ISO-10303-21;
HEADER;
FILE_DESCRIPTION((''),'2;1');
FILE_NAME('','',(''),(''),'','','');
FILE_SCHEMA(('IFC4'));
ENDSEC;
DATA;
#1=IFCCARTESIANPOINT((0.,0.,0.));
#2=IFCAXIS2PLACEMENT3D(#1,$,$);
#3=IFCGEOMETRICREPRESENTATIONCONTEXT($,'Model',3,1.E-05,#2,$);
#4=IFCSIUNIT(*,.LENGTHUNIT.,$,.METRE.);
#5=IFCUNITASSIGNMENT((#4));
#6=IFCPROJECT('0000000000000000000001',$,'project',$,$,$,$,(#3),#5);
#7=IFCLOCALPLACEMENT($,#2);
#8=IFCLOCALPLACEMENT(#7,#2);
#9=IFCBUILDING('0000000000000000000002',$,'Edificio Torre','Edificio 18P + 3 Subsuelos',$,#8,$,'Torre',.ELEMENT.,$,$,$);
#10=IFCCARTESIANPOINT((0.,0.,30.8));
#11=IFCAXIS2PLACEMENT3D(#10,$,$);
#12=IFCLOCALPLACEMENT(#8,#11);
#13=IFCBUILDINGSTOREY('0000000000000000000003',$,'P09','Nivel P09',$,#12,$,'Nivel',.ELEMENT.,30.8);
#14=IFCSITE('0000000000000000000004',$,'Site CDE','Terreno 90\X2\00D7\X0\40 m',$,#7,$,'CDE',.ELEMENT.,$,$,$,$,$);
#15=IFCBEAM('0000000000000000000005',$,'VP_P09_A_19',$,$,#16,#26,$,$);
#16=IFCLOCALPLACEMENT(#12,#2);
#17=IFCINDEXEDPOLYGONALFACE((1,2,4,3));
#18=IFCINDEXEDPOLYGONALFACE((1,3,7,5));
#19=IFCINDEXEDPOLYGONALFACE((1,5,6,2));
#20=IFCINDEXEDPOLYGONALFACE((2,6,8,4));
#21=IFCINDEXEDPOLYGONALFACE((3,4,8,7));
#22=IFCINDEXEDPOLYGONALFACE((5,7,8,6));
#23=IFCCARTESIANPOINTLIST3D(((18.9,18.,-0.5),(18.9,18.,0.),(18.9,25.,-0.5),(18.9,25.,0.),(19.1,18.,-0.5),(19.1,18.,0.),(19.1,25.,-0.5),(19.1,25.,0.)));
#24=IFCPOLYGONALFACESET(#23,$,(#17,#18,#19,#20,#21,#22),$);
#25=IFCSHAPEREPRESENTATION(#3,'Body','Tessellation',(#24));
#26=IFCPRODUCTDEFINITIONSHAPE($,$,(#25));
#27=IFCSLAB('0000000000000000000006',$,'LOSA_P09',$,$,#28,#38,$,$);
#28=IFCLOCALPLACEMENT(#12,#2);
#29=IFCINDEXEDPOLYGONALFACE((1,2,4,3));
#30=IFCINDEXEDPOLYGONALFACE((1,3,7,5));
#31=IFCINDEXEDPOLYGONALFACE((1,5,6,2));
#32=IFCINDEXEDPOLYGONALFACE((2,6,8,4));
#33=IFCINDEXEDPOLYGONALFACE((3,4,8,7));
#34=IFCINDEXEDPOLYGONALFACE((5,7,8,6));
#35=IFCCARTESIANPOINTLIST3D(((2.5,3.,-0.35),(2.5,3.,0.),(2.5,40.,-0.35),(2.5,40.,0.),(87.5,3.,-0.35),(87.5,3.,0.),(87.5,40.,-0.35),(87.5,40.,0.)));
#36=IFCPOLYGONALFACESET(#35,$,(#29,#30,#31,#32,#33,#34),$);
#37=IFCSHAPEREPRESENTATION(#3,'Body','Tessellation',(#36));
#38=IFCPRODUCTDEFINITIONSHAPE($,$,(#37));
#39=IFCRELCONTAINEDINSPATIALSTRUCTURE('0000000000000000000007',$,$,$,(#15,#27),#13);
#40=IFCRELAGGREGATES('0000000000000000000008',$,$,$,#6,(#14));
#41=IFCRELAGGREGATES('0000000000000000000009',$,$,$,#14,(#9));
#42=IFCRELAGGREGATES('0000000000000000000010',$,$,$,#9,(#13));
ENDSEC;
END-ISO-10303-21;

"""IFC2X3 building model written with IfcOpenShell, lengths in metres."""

from ifc_helpers import new_model, si_unit, frame, origin, origin_2d, place, context, project, spatial, rectangle, extrude, element, save


model = new_model("IFC2X3")

# Units and contexts
model_context = context("Model", 3, precision=1e-05, world=origin())
ifc_project = project(units=[si_unit("LENGTHUNIT", "METRE")], contexts=[model_context])

# Site, building, storey
site_placement = place(None, origin())
site = spatial("IfcSite", under=ifc_project, at=site_placement, Name="Site CDE", Description="Terreno 90×40 m", LongName="CDE", CompositionType="ELEMENT")
building_placement = place(site_placement, origin())
building = spatial("IfcBuilding", under=site, at=building_placement, Name="Edificio Torre", Description="Edificio 18P + 3 Subsuelos", LongName="Torre", CompositionType="ELEMENT")
storey_placement = place(building_placement, frame((0.0, 0.0, 30.8)))
storey = spatial("IfcBuildingStorey", under=building, at=storey_placement, Name="P09", Description="Nivel P09", LongName="Nivel", CompositionType="ELEMENT", Elevation=30.8)

# Beam
beam_1_placement = place(storey_placement, frame((19.0, 21.5, -0.5)))
element("IfcBeam", 1, at=beam_1_placement, inside=storey, Name="VP_P09_A_19", context=model_context, shape_type="SweptSolid", body=[
    extrude(rectangle(XDim=0.2, YDim=7.0, at=origin_2d()), origin(), (0.0, 0.0, 1.0), 0.5),
])

# Slab
slab_placement = place(storey_placement, frame((45.0, 21.5, -0.35)))
element("IfcSlab", 2, at=slab_placement, inside=storey, Name="LOSA_P09", context=model_context, shape_type="SweptSolid", body=[
    extrude(rectangle(XDim=85.0, YDim=37.0, at=origin_2d()), origin(), (0.0, 0.0, 1.0), 0.35),
])

save(model, "model.ifc")
